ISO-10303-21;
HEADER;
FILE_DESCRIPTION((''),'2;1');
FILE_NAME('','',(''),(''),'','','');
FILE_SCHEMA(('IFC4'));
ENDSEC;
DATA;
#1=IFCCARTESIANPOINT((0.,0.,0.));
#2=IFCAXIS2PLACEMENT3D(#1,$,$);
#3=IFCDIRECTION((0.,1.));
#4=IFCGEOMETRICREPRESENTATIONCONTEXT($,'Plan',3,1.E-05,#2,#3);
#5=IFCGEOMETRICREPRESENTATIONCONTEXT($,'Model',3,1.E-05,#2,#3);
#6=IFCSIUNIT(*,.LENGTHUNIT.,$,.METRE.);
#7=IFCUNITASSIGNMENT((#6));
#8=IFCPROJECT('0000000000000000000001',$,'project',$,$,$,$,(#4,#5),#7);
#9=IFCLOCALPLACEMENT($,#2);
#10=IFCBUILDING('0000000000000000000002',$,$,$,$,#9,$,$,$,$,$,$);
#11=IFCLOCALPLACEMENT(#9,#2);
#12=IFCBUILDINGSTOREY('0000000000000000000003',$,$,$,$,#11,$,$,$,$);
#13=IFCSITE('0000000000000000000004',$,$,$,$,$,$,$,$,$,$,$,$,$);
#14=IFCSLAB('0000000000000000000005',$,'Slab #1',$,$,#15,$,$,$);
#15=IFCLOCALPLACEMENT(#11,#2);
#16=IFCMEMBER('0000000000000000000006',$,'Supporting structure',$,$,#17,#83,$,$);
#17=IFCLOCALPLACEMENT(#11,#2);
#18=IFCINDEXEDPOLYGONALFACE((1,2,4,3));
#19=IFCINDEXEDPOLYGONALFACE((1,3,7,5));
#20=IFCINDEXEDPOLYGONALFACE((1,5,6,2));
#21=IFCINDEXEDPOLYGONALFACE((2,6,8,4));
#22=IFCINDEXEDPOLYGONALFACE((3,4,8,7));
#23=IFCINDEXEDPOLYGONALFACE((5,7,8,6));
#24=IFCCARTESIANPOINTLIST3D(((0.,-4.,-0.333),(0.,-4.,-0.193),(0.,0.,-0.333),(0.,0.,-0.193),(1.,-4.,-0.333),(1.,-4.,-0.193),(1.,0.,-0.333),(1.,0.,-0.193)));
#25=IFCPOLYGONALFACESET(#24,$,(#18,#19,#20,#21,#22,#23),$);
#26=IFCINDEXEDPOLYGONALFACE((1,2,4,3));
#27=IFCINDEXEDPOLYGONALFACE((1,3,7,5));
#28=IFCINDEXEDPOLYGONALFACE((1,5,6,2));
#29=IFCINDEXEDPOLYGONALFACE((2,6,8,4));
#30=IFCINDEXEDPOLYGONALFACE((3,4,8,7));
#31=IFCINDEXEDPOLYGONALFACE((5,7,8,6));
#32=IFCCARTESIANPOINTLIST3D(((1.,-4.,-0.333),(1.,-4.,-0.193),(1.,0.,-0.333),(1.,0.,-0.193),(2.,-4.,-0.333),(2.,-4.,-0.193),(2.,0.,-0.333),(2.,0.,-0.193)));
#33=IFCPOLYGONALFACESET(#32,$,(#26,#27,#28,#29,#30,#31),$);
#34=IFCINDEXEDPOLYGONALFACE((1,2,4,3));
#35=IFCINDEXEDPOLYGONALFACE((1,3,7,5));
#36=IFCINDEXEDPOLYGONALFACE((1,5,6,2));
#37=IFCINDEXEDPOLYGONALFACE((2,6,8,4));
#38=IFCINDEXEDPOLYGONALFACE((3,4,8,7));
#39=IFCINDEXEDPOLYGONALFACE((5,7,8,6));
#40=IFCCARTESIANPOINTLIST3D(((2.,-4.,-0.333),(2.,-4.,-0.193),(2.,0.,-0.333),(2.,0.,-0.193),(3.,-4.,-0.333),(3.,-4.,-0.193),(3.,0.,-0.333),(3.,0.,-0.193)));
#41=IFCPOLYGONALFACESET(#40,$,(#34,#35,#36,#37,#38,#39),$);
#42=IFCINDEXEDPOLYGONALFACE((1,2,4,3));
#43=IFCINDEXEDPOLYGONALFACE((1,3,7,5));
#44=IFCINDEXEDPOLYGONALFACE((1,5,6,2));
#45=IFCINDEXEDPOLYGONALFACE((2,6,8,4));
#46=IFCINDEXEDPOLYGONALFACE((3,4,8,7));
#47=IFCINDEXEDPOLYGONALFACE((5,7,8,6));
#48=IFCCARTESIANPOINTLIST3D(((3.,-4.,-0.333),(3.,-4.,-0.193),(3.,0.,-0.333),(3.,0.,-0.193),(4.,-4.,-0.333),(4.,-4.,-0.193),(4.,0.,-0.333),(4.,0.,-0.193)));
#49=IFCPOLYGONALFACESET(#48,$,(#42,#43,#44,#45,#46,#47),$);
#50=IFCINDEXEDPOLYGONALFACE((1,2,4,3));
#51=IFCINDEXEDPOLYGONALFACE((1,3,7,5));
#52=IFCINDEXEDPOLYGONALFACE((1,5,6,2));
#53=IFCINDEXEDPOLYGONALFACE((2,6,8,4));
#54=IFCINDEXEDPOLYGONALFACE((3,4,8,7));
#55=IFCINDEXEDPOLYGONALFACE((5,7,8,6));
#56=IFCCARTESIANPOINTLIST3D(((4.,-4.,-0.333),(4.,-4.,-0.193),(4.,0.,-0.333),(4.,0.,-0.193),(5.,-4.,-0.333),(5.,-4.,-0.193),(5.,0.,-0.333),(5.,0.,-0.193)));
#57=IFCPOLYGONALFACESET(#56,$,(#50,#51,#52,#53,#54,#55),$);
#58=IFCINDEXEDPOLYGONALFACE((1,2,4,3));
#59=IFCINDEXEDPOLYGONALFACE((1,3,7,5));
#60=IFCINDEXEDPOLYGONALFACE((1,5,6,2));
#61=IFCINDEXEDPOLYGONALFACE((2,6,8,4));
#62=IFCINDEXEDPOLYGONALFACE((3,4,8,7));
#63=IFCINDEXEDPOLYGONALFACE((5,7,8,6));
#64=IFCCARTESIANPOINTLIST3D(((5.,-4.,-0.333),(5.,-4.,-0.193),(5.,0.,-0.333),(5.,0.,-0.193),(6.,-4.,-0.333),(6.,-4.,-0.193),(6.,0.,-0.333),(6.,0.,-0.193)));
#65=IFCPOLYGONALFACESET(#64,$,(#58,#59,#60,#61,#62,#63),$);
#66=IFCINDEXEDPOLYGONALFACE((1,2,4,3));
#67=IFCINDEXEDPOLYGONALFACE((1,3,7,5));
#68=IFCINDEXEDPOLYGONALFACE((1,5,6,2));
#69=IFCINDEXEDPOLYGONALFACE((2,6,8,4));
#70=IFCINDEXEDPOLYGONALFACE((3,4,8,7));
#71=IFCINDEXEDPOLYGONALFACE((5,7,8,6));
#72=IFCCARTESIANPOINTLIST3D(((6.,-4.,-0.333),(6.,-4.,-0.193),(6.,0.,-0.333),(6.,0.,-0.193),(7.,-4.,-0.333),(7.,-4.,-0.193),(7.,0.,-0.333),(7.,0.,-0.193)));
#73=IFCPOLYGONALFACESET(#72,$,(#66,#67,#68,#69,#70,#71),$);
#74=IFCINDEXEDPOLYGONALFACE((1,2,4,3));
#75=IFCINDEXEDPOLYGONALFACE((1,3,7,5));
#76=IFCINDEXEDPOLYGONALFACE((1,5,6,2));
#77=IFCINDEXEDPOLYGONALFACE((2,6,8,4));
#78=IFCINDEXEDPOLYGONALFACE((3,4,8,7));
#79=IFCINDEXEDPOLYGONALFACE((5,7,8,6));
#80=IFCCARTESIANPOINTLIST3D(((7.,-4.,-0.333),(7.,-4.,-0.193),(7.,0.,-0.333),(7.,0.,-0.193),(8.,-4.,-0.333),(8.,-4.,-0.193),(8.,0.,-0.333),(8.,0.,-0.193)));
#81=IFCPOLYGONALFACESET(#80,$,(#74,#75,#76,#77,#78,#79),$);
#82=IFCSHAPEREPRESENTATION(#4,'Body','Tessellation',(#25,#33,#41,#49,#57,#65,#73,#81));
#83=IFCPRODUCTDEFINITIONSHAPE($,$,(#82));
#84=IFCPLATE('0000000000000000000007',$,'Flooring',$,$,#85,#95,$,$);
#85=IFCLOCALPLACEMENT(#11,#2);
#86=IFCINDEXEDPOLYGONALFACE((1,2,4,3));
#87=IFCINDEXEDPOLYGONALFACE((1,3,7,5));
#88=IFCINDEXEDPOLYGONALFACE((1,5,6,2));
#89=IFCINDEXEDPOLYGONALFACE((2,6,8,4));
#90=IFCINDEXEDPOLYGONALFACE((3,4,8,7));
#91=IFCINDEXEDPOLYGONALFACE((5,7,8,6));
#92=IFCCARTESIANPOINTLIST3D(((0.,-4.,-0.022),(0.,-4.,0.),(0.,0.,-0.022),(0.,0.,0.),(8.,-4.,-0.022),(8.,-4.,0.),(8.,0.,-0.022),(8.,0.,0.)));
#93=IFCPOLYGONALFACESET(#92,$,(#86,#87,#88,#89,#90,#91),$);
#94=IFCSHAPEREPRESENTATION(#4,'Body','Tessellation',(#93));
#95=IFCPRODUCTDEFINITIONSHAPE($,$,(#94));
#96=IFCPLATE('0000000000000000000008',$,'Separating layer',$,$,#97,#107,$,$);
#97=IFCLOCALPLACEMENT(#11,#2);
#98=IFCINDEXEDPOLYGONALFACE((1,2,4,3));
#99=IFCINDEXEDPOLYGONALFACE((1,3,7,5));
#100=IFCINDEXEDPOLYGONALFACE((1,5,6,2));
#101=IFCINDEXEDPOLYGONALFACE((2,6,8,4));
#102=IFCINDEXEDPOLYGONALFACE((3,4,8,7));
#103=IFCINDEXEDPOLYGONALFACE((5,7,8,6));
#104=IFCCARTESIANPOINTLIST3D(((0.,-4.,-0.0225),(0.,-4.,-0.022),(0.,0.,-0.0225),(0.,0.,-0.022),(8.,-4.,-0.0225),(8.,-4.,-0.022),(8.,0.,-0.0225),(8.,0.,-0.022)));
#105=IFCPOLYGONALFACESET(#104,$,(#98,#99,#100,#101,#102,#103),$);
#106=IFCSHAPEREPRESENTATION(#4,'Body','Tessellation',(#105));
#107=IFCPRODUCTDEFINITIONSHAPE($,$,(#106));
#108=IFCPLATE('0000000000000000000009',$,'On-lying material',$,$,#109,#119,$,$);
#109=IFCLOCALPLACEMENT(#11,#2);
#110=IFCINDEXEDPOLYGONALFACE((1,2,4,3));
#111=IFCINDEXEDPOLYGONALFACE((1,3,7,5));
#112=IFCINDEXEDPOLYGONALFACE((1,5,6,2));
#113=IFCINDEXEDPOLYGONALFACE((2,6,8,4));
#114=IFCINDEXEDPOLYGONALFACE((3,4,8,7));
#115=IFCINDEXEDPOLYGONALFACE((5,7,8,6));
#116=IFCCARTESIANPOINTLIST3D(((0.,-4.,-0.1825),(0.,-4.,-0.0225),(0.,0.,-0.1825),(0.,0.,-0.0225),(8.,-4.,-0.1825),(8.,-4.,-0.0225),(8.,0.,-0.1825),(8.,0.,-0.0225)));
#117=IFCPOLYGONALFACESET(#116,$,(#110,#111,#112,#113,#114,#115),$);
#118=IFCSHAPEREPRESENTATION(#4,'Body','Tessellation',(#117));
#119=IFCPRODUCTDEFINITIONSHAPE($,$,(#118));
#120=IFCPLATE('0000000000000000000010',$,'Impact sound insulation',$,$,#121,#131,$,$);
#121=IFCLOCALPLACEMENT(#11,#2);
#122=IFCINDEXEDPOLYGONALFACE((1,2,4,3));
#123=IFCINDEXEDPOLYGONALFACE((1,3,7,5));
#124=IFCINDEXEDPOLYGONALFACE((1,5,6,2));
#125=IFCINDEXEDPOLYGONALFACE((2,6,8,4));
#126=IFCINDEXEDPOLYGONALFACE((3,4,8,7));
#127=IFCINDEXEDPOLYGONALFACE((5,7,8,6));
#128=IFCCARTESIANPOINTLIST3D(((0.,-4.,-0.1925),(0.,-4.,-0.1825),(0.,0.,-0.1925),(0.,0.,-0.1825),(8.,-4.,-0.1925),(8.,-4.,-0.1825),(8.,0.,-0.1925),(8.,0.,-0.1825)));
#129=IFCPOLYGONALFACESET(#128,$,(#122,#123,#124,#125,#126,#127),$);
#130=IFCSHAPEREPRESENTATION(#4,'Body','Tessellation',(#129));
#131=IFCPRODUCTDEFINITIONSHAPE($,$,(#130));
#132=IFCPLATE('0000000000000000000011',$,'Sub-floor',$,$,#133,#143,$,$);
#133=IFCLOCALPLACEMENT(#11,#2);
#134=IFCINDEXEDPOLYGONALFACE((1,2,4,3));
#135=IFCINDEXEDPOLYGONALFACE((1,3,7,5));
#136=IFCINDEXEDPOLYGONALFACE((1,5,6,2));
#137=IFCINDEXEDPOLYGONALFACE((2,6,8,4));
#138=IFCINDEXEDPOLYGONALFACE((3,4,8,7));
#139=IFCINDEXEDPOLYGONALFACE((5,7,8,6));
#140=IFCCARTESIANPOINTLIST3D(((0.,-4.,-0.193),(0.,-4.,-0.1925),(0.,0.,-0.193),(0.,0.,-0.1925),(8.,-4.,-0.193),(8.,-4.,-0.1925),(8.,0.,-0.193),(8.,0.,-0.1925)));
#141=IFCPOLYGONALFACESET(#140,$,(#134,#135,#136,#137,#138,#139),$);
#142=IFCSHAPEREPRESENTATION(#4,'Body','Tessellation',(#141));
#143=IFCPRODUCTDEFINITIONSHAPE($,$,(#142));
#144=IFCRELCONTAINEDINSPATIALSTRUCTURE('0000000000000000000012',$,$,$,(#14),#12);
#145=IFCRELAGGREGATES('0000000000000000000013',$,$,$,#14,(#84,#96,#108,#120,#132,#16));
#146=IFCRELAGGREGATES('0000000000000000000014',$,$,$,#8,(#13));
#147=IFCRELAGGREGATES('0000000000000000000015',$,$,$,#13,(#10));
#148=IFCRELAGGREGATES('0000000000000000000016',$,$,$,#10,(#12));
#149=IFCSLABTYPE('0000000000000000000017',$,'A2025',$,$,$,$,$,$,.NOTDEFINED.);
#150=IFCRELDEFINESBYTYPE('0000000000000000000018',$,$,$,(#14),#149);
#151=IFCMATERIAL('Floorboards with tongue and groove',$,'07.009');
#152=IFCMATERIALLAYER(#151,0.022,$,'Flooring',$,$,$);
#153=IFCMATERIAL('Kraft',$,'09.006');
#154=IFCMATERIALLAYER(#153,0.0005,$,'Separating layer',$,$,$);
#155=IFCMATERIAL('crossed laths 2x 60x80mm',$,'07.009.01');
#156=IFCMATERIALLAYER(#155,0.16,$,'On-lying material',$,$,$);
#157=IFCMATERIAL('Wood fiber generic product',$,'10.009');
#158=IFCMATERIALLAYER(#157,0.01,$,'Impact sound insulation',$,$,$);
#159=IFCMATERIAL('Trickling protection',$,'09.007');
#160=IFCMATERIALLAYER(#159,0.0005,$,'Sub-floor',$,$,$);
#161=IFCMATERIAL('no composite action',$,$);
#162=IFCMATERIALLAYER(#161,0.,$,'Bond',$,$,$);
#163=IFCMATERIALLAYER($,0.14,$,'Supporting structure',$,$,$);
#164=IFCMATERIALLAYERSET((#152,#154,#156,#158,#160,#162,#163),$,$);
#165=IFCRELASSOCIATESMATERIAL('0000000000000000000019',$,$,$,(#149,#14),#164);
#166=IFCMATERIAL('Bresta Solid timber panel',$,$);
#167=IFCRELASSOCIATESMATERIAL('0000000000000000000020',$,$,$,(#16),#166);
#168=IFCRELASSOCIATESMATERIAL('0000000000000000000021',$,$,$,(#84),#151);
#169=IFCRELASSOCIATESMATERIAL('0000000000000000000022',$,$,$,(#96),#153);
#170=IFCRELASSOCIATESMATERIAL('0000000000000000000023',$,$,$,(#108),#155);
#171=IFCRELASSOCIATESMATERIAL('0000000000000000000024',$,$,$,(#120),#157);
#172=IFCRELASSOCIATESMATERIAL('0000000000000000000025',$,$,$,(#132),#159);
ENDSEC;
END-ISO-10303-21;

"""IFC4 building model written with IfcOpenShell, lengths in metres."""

from ifc_helpers import new_model, si_unit, direction, frame, frame_2d, origin, origin_with_axes, place, context, project, spatial, rectangle, extrude, material, layer, layer_set, type_object, element, aggregate, save


model = new_model("IFC4")

# Units and contexts
plan_context = context("Plan", 3, precision=1e-05, world=origin(), true_north=direction((0.0, 1.0)))
model_context = context("Model", 3, precision=1e-05, world=origin(), true_north=direction((0.0, 1.0)))
ifc_project = project(units=[si_unit("LENGTHUNIT", "METRE")], contexts=[plan_context, model_context])

# Site, building, storey
site = spatial("IfcSite", under=ifc_project)
building_placement = place(None, origin())
building = spatial("IfcBuilding", under=site, at=building_placement)
storey_placement = place(building_placement, origin())
storey = spatial("IfcBuildingStorey", under=building, at=storey_placement)

# Slab, member, plates
ifc_material_1 = material(Name="Floorboards with tongue and groove", Category="07.009")
ifc_layer_1 = layer(ifc_material_1, 0.022, Name="Flooring")
ifc_material_2 = material(Name="Kraft", Category="09.006")
ifc_layer_2 = layer(ifc_material_2, 0.0005, Name="Separating layer")
ifc_material_3 = material(Name="crossed laths 2x 60x80mm", Category="07.009.01")
ifc_layer_3 = layer(ifc_material_3, 0.16, Name="On-lying material")
ifc_material_4 = material(Name="Wood fiber generic product", Category="10.009")
ifc_layer_4 = layer(ifc_material_4, 0.01, Name="Impact sound insulation")
ifc_material_5 = material(Name="Trickling protection", Category="09.007")
ifc_layer_5 = layer(ifc_material_5, 0.0005, Name="Sub-floor")
ifc_material_6 = material(Name="no composite action")
ifc_layer_6 = layer(ifc_material_6, 0.0, Name="Bond")
ifc_layer_7 = layer(None, 0.14, Name="Supporting structure")
ifc_layer_set = layer_set([ifc_layer_1, ifc_layer_2, ifc_layer_3, ifc_layer_4, ifc_layer_5, ifc_layer_6, ifc_layer_7])
slab_type = type_object("IfcSlabType", Name="A2025", PredefinedType="NOTDEFINED", material=ifc_layer_set)
slab_placement = place(None, frame((0.0, 0.0, 0.0), z_axis=(0.0, 0.0, -1.0), x_axis=(1.0, 0.0, 0.0)))
slab = element("IfcSlab", 1, at=slab_placement, inside=storey, type_object=slab_type, material=ifc_layer_set, Name="Slab #1")
ifc_material_7 = material(Name="Bresta Solid timber panel")
member_placement = place(slab_placement, origin())
member = element("IfcMember", 2, at=member_placement, material=ifc_material_7, Name="Supporting structure", context=plan_context, shape_type="SweptSolid", body=[
    extrude(rectangle(XDim=1.0, YDim=0.14, at=frame_2d((0.5, 0.07), x_axis=(1.0, 0.0))), frame((0.0, 4.0, 0.193), z_axis=(0.0, -1.0, 0.0), x_axis=(1.0, 0.0, 0.0)), (0.0, 0.0, 1.0), 4.0),
    extrude(rectangle(XDim=1.0, YDim=0.14, at=frame_2d((0.5, 0.07), x_axis=(1.0, 0.0))), frame((1.0, 4.0, 0.193), z_axis=(0.0, -1.0, 0.0), x_axis=(1.0, 0.0, 0.0)), (0.0, 0.0, 1.0), 4.0),
    extrude(rectangle(XDim=1.0, YDim=0.14, at=frame_2d((0.5, 0.07), x_axis=(1.0, 0.0))), frame((2.0, 4.0, 0.193), z_axis=(0.0, -1.0, 0.0), x_axis=(1.0, 0.0, 0.0)), (0.0, 0.0, 1.0), 4.0),
    extrude(rectangle(XDim=1.0, YDim=0.14, at=frame_2d((0.5, 0.07), x_axis=(1.0, 0.0))), frame((3.0, 4.0, 0.193), z_axis=(0.0, -1.0, 0.0), x_axis=(1.0, 0.0, 0.0)), (0.0, 0.0, 1.0), 4.0),
    extrude(rectangle(XDim=1.0, YDim=0.14, at=frame_2d((0.5, 0.07), x_axis=(1.0, 0.0))), frame((4.0, 4.0, 0.193), z_axis=(0.0, -1.0, 0.0), x_axis=(1.0, 0.0, 0.0)), (0.0, 0.0, 1.0), 4.0),
    extrude(rectangle(XDim=1.0, YDim=0.14, at=frame_2d((0.5, 0.07), x_axis=(1.0, 0.0))), frame((5.0, 4.0, 0.193), z_axis=(0.0, -1.0, 0.0), x_axis=(1.0, 0.0, 0.0)), (0.0, 0.0, 1.0), 4.0),
    extrude(rectangle(XDim=1.0, YDim=0.14, at=frame_2d((0.5, 0.07), x_axis=(1.0, 0.0))), frame((6.0, 4.0, 0.193), z_axis=(0.0, -1.0, 0.0), x_axis=(1.0, 0.0, 0.0)), (0.0, 0.0, 1.0), 4.0),
    extrude(rectangle(XDim=1.0, YDim=0.14, at=frame_2d((0.5, 0.07), x_axis=(1.0, 0.0))), frame((7.0, 4.0, 0.193), z_axis=(0.0, -1.0, 0.0), x_axis=(1.0, 0.0, 0.0)), (0.0, 0.0, 1.0), 4.0),
])
plate_1_placement = place(slab_placement, origin())
plate_1 = element("IfcPlate", 3, at=plate_1_placement, material=ifc_material_1, Name="Flooring", context=plan_context, shape_type="SweptSolid", body=[
    extrude(rectangle(XDim=8.0, YDim=4.0, at=frame_2d((4.0, 2.0), x_axis=(1.0, 0.0))), origin_with_axes(), (0.0, 0.0, 1.0), 0.022),
])
plate_2_placement = place(slab_placement, origin())
plate_2 = element("IfcPlate", 4, at=plate_2_placement, material=ifc_material_2, Name="Separating layer", context=plan_context, shape_type="SweptSolid", body=[
    extrude(rectangle(XDim=8.0, YDim=4.0, at=frame_2d((4.0, 2.0), x_axis=(1.0, 0.0))), frame((0.0, 0.0, 0.022), z_axis=(0.0, 0.0, 1.0), x_axis=(1.0, 0.0, 0.0)), (0.0, 0.0, 1.0), 0.0005),
])
plate_3_placement = place(slab_placement, origin())
plate_3 = element("IfcPlate", 5, at=plate_3_placement, material=ifc_material_3, Name="On-lying material", context=plan_context, shape_type="SweptSolid", body=[
    extrude(rectangle(XDim=8.0, YDim=4.0, at=frame_2d((4.0, 2.0), x_axis=(1.0, 0.0))), frame((0.0, 0.0, 0.0225), z_axis=(0.0, 0.0, 1.0), x_axis=(1.0, 0.0, 0.0)), (0.0, 0.0, 1.0), 0.16),
])
plate_4_placement = place(slab_placement, origin())
plate_4 = element("IfcPlate", 6, at=plate_4_placement, material=ifc_material_4, Name="Impact sound insulation", context=plan_context, shape_type="SweptSolid", body=[
    extrude(rectangle(XDim=8.0, YDim=4.0, at=frame_2d((4.0, 2.0), x_axis=(1.0, 0.0))), frame((0.0, 0.0, 0.1825), z_axis=(0.0, 0.0, 1.0), x_axis=(1.0, 0.0, 0.0)), (0.0, 0.0, 1.0), 0.01),
])
plate_5_placement = place(slab_placement, origin())
plate_5 = element("IfcPlate", 7, at=plate_5_placement, material=ifc_material_5, Name="Sub-floor", context=plan_context, shape_type="SweptSolid", body=[
    extrude(rectangle(XDim=8.0, YDim=4.0, at=frame_2d((4.0, 2.0), x_axis=(1.0, 0.0))), frame((0.0, 0.0, 0.1925), z_axis=(0.0, 0.0, 1.0), x_axis=(1.0, 0.0, 0.0)), (0.0, 0.0, 1.0), 0.0005),
])
aggregate(slab, [plate_1, plate_2, plate_3, plate_4, plate_5, member])

save(model, "model.ifc")
